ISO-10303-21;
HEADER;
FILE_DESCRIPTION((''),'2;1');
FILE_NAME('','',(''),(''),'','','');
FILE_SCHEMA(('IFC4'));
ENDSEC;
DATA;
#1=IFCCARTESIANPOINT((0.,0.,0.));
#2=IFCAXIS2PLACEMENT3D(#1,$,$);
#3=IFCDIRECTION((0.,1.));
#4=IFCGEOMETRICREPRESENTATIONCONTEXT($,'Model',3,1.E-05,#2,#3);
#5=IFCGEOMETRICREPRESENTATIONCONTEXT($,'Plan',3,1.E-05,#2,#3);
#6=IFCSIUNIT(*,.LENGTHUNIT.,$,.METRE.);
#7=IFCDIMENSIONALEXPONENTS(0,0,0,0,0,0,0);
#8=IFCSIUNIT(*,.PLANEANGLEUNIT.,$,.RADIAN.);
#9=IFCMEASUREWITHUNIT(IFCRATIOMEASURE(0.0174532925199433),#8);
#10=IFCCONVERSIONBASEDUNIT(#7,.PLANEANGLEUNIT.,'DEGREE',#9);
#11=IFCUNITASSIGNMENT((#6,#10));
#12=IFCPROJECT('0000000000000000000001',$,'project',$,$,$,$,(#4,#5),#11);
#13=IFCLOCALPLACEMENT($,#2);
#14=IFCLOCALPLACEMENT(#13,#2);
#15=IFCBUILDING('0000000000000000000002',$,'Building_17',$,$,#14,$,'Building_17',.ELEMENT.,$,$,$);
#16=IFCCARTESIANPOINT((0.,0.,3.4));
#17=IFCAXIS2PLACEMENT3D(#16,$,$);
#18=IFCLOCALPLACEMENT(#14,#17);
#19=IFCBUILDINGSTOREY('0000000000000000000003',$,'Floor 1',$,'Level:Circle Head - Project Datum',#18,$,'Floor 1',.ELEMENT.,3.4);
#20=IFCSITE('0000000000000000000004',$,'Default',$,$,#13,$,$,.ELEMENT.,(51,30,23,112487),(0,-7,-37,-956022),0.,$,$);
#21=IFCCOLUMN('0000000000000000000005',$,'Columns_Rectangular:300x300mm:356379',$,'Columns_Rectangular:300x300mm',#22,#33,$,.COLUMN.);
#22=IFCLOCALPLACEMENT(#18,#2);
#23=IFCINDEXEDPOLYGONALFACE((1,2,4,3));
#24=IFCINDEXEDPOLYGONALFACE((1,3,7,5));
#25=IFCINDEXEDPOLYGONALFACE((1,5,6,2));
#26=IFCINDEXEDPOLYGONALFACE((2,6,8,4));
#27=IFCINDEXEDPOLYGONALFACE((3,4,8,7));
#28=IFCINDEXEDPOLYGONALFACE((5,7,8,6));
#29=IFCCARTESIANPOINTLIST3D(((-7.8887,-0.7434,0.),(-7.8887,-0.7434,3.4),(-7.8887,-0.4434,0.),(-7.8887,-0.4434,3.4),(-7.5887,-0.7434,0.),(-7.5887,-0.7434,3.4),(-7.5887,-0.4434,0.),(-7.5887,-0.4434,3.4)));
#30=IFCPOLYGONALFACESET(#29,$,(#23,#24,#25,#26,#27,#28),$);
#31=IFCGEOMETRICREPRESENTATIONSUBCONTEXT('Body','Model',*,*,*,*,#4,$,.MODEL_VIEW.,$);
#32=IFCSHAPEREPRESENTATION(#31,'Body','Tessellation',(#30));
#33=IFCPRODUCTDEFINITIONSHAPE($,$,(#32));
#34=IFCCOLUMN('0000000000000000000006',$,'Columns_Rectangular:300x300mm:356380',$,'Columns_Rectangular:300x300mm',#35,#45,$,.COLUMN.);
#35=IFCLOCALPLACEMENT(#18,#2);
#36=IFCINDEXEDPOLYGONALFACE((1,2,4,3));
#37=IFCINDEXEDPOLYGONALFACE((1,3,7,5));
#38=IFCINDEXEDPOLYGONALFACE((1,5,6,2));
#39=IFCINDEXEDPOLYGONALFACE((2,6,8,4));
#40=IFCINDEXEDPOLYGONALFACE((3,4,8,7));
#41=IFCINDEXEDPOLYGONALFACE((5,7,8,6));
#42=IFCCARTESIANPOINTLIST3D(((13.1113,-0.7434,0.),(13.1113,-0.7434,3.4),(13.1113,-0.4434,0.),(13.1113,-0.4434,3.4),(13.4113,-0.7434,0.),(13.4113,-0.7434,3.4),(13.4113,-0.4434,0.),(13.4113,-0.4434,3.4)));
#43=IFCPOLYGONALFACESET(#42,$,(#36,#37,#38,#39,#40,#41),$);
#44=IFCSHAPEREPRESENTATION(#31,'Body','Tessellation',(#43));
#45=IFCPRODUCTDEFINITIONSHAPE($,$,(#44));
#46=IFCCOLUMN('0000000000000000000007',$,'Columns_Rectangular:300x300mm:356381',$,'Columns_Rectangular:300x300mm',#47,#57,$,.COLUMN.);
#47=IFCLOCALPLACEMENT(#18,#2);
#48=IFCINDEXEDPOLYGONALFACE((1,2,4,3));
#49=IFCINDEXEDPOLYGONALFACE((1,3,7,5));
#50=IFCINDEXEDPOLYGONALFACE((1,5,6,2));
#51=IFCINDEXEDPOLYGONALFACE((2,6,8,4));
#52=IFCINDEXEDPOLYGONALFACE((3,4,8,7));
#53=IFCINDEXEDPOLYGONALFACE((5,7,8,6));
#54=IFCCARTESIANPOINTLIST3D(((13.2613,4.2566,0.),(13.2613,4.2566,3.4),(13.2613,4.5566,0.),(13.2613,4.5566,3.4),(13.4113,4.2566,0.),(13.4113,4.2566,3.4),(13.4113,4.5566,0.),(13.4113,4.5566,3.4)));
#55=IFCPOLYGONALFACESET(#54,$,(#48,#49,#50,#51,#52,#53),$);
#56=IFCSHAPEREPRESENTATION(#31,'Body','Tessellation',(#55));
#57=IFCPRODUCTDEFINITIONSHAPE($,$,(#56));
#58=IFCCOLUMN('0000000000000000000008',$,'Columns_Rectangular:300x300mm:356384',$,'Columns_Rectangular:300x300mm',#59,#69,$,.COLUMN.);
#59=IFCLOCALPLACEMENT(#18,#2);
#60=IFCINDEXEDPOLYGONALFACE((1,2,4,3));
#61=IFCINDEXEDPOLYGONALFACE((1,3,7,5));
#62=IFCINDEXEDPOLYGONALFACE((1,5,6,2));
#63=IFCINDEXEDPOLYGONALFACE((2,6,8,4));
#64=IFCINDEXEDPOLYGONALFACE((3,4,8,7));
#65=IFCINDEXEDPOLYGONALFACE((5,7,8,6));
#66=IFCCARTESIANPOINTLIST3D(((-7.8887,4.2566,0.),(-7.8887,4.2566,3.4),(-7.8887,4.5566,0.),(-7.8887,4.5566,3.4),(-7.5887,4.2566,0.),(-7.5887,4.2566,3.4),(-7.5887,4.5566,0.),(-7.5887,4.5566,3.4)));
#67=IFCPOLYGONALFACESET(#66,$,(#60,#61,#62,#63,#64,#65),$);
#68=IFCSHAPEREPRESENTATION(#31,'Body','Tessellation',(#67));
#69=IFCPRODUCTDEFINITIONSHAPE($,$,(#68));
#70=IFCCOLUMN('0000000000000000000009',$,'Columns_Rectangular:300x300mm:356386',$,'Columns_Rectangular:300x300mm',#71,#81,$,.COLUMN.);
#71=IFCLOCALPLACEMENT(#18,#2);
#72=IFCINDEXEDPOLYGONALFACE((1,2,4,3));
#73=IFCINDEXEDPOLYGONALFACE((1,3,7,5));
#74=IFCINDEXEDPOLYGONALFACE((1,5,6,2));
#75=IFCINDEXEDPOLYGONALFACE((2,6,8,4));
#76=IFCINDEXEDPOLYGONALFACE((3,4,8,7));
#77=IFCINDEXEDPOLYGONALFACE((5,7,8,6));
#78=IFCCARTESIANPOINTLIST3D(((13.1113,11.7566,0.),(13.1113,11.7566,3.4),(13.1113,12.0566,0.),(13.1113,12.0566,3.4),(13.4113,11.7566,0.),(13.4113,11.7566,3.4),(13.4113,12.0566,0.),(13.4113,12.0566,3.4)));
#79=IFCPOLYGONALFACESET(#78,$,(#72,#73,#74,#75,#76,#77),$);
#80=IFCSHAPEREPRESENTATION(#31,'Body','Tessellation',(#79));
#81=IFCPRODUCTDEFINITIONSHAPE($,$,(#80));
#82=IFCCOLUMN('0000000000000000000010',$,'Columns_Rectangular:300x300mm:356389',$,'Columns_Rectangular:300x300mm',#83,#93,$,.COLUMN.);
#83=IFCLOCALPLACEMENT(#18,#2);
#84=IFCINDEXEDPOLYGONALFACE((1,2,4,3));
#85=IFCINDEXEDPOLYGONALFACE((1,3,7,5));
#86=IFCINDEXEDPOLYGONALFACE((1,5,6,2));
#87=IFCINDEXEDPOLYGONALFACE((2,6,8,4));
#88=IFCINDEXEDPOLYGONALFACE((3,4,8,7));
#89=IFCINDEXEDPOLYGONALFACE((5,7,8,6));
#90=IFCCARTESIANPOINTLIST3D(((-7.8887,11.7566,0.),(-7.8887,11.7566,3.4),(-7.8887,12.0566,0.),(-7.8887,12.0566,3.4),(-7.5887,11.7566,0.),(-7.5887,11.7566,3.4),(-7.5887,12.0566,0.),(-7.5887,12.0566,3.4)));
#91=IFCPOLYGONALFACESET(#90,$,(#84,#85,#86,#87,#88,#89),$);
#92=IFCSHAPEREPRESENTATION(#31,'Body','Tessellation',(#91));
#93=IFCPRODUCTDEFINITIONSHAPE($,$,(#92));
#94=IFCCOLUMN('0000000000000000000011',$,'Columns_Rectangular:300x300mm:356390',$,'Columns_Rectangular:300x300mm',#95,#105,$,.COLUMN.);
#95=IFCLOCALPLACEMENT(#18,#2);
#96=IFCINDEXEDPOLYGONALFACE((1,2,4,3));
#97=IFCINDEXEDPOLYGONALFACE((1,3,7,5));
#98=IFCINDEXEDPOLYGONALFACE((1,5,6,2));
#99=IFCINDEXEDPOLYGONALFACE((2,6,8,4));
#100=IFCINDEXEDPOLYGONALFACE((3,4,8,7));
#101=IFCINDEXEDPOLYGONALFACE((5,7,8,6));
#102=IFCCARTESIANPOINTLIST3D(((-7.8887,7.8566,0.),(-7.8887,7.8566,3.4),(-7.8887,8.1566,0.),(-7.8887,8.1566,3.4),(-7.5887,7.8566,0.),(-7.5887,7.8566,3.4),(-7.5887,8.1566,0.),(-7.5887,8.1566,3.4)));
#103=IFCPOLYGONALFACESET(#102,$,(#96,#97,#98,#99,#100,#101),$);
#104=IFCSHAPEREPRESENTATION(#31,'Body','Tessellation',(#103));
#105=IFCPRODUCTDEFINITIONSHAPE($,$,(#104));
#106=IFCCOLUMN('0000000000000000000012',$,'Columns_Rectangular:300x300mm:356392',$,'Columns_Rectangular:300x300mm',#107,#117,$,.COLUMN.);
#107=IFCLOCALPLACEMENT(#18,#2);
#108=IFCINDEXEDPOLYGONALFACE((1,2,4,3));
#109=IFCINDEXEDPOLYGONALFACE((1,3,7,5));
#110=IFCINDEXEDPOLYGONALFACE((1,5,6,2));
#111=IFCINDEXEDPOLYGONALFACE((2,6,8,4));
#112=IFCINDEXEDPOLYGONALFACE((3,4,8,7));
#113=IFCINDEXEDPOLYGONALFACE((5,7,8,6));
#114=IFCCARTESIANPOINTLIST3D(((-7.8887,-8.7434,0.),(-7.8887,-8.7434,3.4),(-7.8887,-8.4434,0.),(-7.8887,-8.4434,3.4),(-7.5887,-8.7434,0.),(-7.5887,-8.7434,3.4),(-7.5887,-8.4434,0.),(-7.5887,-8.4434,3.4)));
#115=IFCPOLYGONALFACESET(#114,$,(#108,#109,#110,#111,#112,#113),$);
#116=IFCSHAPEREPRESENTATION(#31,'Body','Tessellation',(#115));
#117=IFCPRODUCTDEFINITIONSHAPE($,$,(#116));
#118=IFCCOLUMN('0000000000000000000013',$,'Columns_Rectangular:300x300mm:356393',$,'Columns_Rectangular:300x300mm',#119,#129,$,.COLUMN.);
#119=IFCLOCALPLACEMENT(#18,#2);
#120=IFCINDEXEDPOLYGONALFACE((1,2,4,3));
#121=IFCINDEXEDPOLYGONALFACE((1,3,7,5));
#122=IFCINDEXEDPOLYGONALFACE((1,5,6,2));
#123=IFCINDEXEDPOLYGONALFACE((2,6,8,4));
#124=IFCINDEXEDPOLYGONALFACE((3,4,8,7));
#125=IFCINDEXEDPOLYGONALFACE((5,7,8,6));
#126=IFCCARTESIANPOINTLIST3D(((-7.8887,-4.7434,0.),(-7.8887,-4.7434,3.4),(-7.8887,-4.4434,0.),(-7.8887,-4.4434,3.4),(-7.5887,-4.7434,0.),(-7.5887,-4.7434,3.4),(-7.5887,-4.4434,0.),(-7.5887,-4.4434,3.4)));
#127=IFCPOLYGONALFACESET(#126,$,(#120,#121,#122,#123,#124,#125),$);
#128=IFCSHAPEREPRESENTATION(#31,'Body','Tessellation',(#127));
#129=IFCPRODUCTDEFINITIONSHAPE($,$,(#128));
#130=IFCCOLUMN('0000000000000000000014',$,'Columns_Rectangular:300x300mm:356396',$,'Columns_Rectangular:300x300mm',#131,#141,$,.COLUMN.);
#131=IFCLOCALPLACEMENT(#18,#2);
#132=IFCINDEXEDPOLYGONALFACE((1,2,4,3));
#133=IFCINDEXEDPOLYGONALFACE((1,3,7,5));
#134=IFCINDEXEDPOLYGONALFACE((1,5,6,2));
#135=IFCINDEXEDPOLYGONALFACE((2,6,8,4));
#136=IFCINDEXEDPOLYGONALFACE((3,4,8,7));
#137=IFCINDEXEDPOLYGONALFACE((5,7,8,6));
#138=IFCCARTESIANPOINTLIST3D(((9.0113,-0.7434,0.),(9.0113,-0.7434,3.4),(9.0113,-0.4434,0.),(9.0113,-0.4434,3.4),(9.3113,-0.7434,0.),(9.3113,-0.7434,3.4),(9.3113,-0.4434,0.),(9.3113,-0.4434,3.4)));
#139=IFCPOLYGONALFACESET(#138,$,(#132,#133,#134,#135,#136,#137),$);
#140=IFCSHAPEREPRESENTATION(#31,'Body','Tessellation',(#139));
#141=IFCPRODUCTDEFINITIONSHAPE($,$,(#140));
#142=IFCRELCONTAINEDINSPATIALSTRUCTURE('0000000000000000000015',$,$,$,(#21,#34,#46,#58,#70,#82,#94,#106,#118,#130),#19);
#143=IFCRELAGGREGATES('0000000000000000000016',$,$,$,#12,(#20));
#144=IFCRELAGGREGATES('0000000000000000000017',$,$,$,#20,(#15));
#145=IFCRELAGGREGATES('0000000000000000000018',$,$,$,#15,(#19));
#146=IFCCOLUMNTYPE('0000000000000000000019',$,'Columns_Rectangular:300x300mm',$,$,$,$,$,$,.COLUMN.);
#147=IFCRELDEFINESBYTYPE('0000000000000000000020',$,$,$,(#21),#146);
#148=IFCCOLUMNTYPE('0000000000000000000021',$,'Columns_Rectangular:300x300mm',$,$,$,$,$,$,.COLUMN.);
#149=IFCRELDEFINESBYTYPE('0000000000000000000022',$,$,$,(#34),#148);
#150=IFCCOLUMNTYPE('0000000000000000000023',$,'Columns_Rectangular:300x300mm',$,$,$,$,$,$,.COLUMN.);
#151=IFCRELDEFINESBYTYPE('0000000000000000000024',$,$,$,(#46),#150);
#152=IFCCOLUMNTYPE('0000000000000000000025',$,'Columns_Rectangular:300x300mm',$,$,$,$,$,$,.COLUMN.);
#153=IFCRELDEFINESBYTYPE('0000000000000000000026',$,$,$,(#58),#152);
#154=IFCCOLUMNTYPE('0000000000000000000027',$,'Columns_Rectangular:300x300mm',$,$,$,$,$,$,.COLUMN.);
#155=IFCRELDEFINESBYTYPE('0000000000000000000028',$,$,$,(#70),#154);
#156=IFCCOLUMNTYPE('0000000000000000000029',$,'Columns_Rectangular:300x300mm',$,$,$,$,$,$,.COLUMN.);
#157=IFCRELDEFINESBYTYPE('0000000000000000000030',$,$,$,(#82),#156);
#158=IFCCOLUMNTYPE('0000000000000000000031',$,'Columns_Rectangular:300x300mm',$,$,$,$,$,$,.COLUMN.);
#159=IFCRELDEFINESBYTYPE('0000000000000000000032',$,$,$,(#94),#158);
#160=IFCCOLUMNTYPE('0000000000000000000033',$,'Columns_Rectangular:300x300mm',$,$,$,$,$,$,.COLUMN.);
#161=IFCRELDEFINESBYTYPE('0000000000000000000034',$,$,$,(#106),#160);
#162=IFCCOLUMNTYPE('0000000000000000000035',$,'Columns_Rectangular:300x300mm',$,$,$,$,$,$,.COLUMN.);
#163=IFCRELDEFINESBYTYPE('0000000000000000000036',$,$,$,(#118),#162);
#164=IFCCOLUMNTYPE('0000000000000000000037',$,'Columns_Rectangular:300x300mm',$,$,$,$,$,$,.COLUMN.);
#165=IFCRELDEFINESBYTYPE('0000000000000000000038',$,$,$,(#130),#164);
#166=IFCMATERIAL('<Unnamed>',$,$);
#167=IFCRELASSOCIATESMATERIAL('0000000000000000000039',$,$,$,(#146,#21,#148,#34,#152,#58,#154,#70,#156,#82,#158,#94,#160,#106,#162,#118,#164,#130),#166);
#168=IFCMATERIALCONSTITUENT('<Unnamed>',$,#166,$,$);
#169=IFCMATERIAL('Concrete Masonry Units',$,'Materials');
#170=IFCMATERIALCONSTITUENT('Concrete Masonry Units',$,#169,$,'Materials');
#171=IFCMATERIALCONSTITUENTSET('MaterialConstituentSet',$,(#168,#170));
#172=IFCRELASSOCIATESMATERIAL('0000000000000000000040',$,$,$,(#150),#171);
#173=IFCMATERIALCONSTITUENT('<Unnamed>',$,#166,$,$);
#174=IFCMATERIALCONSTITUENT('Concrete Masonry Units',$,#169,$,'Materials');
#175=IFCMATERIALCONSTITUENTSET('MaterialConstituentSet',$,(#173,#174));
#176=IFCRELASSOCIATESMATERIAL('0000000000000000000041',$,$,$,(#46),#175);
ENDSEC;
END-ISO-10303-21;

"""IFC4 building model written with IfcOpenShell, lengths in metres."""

from ifc_helpers import new_model, entity, si_unit, converted_unit, direction, frame, origin, place, context, subcontext, project, spatial, indexed_curve, outline, extrude, source, transform, mapped, material, constituent, constituent_set, type_object, type_shapes, element, save


model = new_model("IFC4")

# Units and contexts
model_context = context("Model", 3, precision=1e-05, world=origin(), true_north=direction((0.0, 1.0)))
plan_context = context("Plan", 3, precision=1e-05, world=origin(), true_north=direction((0.0, 1.0)))
body_context = subcontext(model_context, "Body", "Model", "MODEL_VIEW")
ifc_project = project(units=[si_unit("LENGTHUNIT", "METRE"), converted_unit("PLANEANGLEUNIT", "DEGREE", entity("IfcRatioMeasure", 0.0174532925199433), si_unit("PLANEANGLEUNIT", "RADIAN"), dimensions=[0, 0, 0, 0, 0, 0, 0])], contexts=[model_context, plan_context])

# Site, building, storey
site_placement = place(None, origin())
site = spatial("IfcSite", under=ifc_project, at=site_placement, Name="Default", CompositionType="ELEMENT", RefLatitude=(51, 30, 23, 112487), RefLongitude=(0, -7, -37, -956022), RefElevation=0.0)
building_placement = place(site_placement, origin())
building = spatial("IfcBuilding", under=site, at=building_placement, Name="Building_17", LongName="Building_17", CompositionType="ELEMENT")
storey_placement = place(building_placement, frame((0.0, 0.0, 3.4)))
storey = spatial("IfcBuildingStorey", under=building, at=storey_placement, Name="Floor 1", ObjectType="Level:Circle Head - Project Datum", LongName="Floor 1", CompositionType="ELEMENT", Elevation=3.4)

# Columns
ifc_material_1 = material(Name="<Unnamed>")
column_type_1 = type_object("IfcColumnType", Name="Columns_Rectangular:300x300mm", PredefinedType="COLUMN", material=ifc_material_1)
shared_shape_1 = source(origin(), body_context, "Body", "SweptSolid", [
    extrude(outline(indexed_curve([(-0.15, -0.15), (0.15, -0.15), (0.15, 0.15), (-0.15, 0.15), (-0.15, -0.15)], self_intersect=False)), frame((-7.7387, -0.5934, 3.4), z_axis=(0.0, 0.0, 1.0), x_axis=(0.0, -1.0, 0.0)), (0.0, 0.0, 1.0), 3.4),
])
type_shapes(column_type_1, [shared_shape_1])
column_1_placement = place(storey_placement, frame((0.0, 0.0, -3.4)))
element("IfcColumn", 1, at=column_1_placement, inside=storey, type_object=column_type_1, material=ifc_material_1, Name="Columns_Rectangular:300x300mm:356379", ObjectType="Columns_Rectangular:300x300mm", PredefinedType="COLUMN", context=body_context, shape_type="MappedRepresentation", body=[
    mapped(shared_shape_1, transform((0.0, 0.0, 0.0), scale=1.0)),
])
column_type_2 = type_object("IfcColumnType", Name="Columns_Rectangular:300x300mm", PredefinedType="COLUMN", material=ifc_material_1)
shared_shape_2 = source(origin(), body_context, "Body", "SweptSolid", [
    extrude(outline(indexed_curve([(-0.15, -0.15), (0.15, -0.15), (0.15, 0.15), (-0.15, 0.15), (-0.15, -0.15)], self_intersect=False)), frame((13.2613, -0.5934, 3.4), z_axis=(0.0, 0.0, 1.0), x_axis=(0.0, -1.0, 0.0)), (0.0, 0.0, 1.0), 3.4),
])
type_shapes(column_type_2, [shared_shape_2])
column_2_placement = place(storey_placement, frame((0.0, 0.0, -3.4)))
element("IfcColumn", 2, at=column_2_placement, inside=storey, type_object=column_type_2, material=ifc_material_1, Name="Columns_Rectangular:300x300mm:356380", ObjectType="Columns_Rectangular:300x300mm", PredefinedType="COLUMN", context=body_context, shape_type="MappedRepresentation", body=[
    mapped(shared_shape_2, transform((0.0, 0.0, 0.0), scale=1.0)),
])
ifc_constituent_1 = constituent(ifc_material_1, Name="<Unnamed>")
ifc_material_2 = material(Name="Concrete Masonry Units", Category="Materials")
ifc_constituent_2 = constituent(ifc_material_2, Name="Concrete Masonry Units", Category="Materials")
ifc_constituent_set_1 = constituent_set(constituents=[ifc_constituent_1, ifc_constituent_2], Name="MaterialConstituentSet")
ifc_constituent_3 = constituent(ifc_material_1, Name="<Unnamed>")
ifc_constituent_4 = constituent(ifc_material_2, Name="Concrete Masonry Units", Category="Materials")
ifc_constituent_set_2 = constituent_set(constituents=[ifc_constituent_3, ifc_constituent_4], Name="MaterialConstituentSet")
column_type_3 = type_object("IfcColumnType", Name="Columns_Rectangular:300x300mm", PredefinedType="COLUMN", material=ifc_constituent_set_2)
shared_shape_3 = source(origin(), body_context, "Body", "SweptSolid", [
    extrude(outline(indexed_curve([(-0.15, -0.075), (0.15, -0.075), (0.15, 0.075), (-0.15, 0.075), (-0.15, -0.075)], self_intersect=False)), frame((13.3363, 4.4066, 3.4), z_axis=(0.0, 0.0, 1.0), x_axis=(0.0, -1.0, 0.0)), (0.0, 0.0, 1.0), 3.4),
])
type_shapes(column_type_3, [shared_shape_3])
column_3_placement = place(storey_placement, frame((0.0, 0.0, -3.4)))
element("IfcColumn", 3, at=column_3_placement, inside=storey, type_object=column_type_3, material=ifc_constituent_set_1, Name="Columns_Rectangular:300x300mm:356381", ObjectType="Columns_Rectangular:300x300mm", PredefinedType="COLUMN", context=body_context, shape_type="MappedRepresentation", body=[
    mapped(shared_shape_3, transform((0.0, 0.0, 0.0), scale=1.0)),
])
column_type_4 = type_object("IfcColumnType", Name="Columns_Rectangular:300x300mm", PredefinedType="COLUMN", material=ifc_material_1)
shared_shape_4 = source(origin(), body_context, "Body", "SweptSolid", [
    extrude(outline(indexed_curve([(-0.15, -0.15), (0.15, -0.15), (0.15, 0.15), (-0.15, 0.15), (-0.15, -0.15)], self_intersect=False)), frame((-7.7387, 4.4066, 3.4), z_axis=(0.0, 0.0, 1.0), x_axis=(0.0, -1.0, 0.0)), (0.0, 0.0, 1.0), 3.4),
])
type_shapes(column_type_4, [shared_shape_4])
column_4_placement = place(storey_placement, frame((0.0, 0.0, -3.4)))
element("IfcColumn", 4, at=column_4_placement, inside=storey, type_object=column_type_4, material=ifc_material_1, Name="Columns_Rectangular:300x300mm:356384", ObjectType="Columns_Rectangular:300x300mm", PredefinedType="COLUMN", context=body_context, shape_type="MappedRepresentation", body=[
    mapped(shared_shape_4, transform((0.0, 0.0, 0.0), scale=1.0)),
])
column_type_5 = type_object("IfcColumnType", Name="Columns_Rectangular:300x300mm", PredefinedType="COLUMN", material=ifc_material_1)
shared_shape_5 = source(origin(), body_context, "Body", "SweptSolid", [
    extrude(outline(indexed_curve([(-0.15, -0.15), (0.15, -0.15), (0.15, 0.15), (-0.15, 0.15), (-0.15, -0.15)], self_intersect=False)), frame((13.2613, 11.9066, 3.4), z_axis=(0.0, 0.0, 1.0), x_axis=(0.0, -1.0, 0.0)), (0.0, 0.0, 1.0), 3.4),
])
type_shapes(column_type_5, [shared_shape_5])
column_5_placement = place(storey_placement, frame((0.0, 0.0, -3.4)))
element("IfcColumn", 5, at=column_5_placement, inside=storey, type_object=column_type_5, material=ifc_material_1, Name="Columns_Rectangular:300x300mm:356386", ObjectType="Columns_Rectangular:300x300mm", PredefinedType="COLUMN", context=body_context, shape_type="MappedRepresentation", body=[
    mapped(shared_shape_5, transform((0.0, 0.0, 0.0), scale=1.0)),
])
column_type_6 = type_object("IfcColumnType", Name="Columns_Rectangular:300x300mm", PredefinedType="COLUMN", material=ifc_material_1)
shared_shape_6 = source(origin(), body_context, "Body", "SweptSolid", [
    extrude(outline(indexed_curve([(-0.15, -0.15), (0.15, -0.15), (0.15, 0.15), (-0.15, 0.15), (-0.15, -0.15)], self_intersect=False)), frame((-7.7387, 11.9066, 3.4), z_axis=(0.0, 0.0, 1.0), x_axis=(0.0, -1.0, 0.0)), (0.0, 0.0, 1.0), 3.4),
])
type_shapes(column_type_6, [shared_shape_6])
column_6_placement = place(storey_placement, frame((0.0, 0.0, -3.4)))
element("IfcColumn", 6, at=column_6_placement, inside=storey, type_object=column_type_6, material=ifc_material_1, Name="Columns_Rectangular:300x300mm:356389", ObjectType="Columns_Rectangular:300x300mm", PredefinedType="COLUMN", context=body_context, shape_type="MappedRepresentation", body=[
    mapped(shared_shape_6, transform((0.0, 0.0, 0.0), scale=1.0)),
])
column_type_7 = type_object("IfcColumnType", Name="Columns_Rectangular:300x300mm", PredefinedType="COLUMN", material=ifc_material_1)
shared_shape_7 = source(origin(), body_context, "Body", "SweptSolid", [
    extrude(outline(indexed_curve([(-0.15, -0.15), (0.15, -0.15), (0.15, 0.15), (-0.15, 0.15), (-0.15, -0.15)], self_intersect=False)), frame((-7.7387, 8.0066, 3.4), z_axis=(0.0, 0.0, 1.0), x_axis=(0.0, -1.0, 0.0)), (0.0, 0.0, 1.0), 3.4),
])
type_shapes(column_type_7, [shared_shape_7])
column_7_placement = place(storey_placement, frame((0.0, 0.0, -3.4)))
element("IfcColumn", 7, at=column_7_placement, inside=storey, type_object=column_type_7, material=ifc_material_1, Name="Columns_Rectangular:300x300mm:356390", ObjectType="Columns_Rectangular:300x300mm", PredefinedType="COLUMN", context=body_context, shape_type="MappedRepresentation", body=[
    mapped(shared_shape_7, transform((0.0, 0.0, 0.0), scale=1.0)),
])
column_type_8 = type_object("IfcColumnType", Name="Columns_Rectangular:300x300mm", PredefinedType="COLUMN", material=ifc_material_1)
shared_shape_8 = source(origin(), body_context, "Body", "SweptSolid", [
    extrude(outline(indexed_curve([(-0.15, -0.15), (0.15, -0.15), (0.15, 0.15), (-0.15, 0.15), (-0.15, -0.15)], self_intersect=False)), frame((-7.7387, -8.5934, 3.4), z_axis=(0.0, 0.0, 1.0), x_axis=(0.0, -1.0, 0.0)), (0.0, 0.0, 1.0), 3.4),
])
type_shapes(column_type_8, [shared_shape_8])
column_8_placement = place(storey_placement, frame((0.0, 0.0, -3.4)))
element("IfcColumn", 8, at=column_8_placement, inside=storey, type_object=column_type_8, material=ifc_material_1, Name="Columns_Rectangular:300x300mm:356392", ObjectType="Columns_Rectangular:300x300mm", PredefinedType="COLUMN", context=body_context, shape_type="MappedRepresentation", body=[
    mapped(shared_shape_8, transform((0.0, 0.0, 0.0), scale=1.0)),
])
column_type_9 = type_object("IfcColumnType", Name="Columns_Rectangular:300x300mm", PredefinedType="COLUMN", material=ifc_material_1)
shared_shape_9 = source(origin(), body_context, "Body", "SweptSolid", [
    extrude(outline(indexed_curve([(-0.15, -0.15), (0.15, -0.15), (0.15, 0.15), (-0.15, 0.15), (-0.15, -0.15)], self_intersect=False)), frame((-7.7387, -4.5934, 3.4), z_axis=(0.0, 0.0, 1.0), x_axis=(0.0, -1.0, 0.0)), (0.0, 0.0, 1.0), 3.4),
])
type_shapes(column_type_9, [shared_shape_9])
column_9_placement = place(storey_placement, frame((0.0, 0.0, -3.4)))
element("IfcColumn", 9, at=column_9_placement, inside=storey, type_object=column_type_9, material=ifc_material_1, Name="Columns_Rectangular:300x300mm:356393", ObjectType="Columns_Rectangular:300x300mm", PredefinedType="COLUMN", context=body_context, shape_type="MappedRepresentation", body=[
    mapped(shared_shape_9, transform((0.0, 0.0, 0.0), scale=1.0)),
])
column_type_10 = type_object("IfcColumnType", Name="Columns_Rectangular:300x300mm", PredefinedType="COLUMN", material=ifc_material_1)
shared_shape_10 = source(origin(), body_context, "Body", "SweptSolid", [
    extrude(outline(indexed_curve([(-0.15, -0.15), (0.15, -0.15), (0.15, 0.15), (-0.15, 0.15), (-0.15, -0.15)], self_intersect=False)), frame((9.1613, -0.5934, 3.4), z_axis=(0.0, 0.0, 1.0), x_axis=(0.0, -1.0, 0.0)), (0.0, 0.0, 1.0), 3.4),
])
type_shapes(column_type_10, [shared_shape_10])
column_10_placement = place(storey_placement, frame((0.0, 0.0, -3.4)))
element("IfcColumn", 10, at=column_10_placement, inside=storey, type_object=column_type_10, material=ifc_material_1, Name="Columns_Rectangular:300x300mm:356396", ObjectType="Columns_Rectangular:300x300mm", PredefinedType="COLUMN", context=body_context, shape_type="MappedRepresentation", body=[
    mapped(shared_shape_10, transform((0.0, 0.0, 0.0), scale=1.0)),
])

save(model, "model.ifc")
